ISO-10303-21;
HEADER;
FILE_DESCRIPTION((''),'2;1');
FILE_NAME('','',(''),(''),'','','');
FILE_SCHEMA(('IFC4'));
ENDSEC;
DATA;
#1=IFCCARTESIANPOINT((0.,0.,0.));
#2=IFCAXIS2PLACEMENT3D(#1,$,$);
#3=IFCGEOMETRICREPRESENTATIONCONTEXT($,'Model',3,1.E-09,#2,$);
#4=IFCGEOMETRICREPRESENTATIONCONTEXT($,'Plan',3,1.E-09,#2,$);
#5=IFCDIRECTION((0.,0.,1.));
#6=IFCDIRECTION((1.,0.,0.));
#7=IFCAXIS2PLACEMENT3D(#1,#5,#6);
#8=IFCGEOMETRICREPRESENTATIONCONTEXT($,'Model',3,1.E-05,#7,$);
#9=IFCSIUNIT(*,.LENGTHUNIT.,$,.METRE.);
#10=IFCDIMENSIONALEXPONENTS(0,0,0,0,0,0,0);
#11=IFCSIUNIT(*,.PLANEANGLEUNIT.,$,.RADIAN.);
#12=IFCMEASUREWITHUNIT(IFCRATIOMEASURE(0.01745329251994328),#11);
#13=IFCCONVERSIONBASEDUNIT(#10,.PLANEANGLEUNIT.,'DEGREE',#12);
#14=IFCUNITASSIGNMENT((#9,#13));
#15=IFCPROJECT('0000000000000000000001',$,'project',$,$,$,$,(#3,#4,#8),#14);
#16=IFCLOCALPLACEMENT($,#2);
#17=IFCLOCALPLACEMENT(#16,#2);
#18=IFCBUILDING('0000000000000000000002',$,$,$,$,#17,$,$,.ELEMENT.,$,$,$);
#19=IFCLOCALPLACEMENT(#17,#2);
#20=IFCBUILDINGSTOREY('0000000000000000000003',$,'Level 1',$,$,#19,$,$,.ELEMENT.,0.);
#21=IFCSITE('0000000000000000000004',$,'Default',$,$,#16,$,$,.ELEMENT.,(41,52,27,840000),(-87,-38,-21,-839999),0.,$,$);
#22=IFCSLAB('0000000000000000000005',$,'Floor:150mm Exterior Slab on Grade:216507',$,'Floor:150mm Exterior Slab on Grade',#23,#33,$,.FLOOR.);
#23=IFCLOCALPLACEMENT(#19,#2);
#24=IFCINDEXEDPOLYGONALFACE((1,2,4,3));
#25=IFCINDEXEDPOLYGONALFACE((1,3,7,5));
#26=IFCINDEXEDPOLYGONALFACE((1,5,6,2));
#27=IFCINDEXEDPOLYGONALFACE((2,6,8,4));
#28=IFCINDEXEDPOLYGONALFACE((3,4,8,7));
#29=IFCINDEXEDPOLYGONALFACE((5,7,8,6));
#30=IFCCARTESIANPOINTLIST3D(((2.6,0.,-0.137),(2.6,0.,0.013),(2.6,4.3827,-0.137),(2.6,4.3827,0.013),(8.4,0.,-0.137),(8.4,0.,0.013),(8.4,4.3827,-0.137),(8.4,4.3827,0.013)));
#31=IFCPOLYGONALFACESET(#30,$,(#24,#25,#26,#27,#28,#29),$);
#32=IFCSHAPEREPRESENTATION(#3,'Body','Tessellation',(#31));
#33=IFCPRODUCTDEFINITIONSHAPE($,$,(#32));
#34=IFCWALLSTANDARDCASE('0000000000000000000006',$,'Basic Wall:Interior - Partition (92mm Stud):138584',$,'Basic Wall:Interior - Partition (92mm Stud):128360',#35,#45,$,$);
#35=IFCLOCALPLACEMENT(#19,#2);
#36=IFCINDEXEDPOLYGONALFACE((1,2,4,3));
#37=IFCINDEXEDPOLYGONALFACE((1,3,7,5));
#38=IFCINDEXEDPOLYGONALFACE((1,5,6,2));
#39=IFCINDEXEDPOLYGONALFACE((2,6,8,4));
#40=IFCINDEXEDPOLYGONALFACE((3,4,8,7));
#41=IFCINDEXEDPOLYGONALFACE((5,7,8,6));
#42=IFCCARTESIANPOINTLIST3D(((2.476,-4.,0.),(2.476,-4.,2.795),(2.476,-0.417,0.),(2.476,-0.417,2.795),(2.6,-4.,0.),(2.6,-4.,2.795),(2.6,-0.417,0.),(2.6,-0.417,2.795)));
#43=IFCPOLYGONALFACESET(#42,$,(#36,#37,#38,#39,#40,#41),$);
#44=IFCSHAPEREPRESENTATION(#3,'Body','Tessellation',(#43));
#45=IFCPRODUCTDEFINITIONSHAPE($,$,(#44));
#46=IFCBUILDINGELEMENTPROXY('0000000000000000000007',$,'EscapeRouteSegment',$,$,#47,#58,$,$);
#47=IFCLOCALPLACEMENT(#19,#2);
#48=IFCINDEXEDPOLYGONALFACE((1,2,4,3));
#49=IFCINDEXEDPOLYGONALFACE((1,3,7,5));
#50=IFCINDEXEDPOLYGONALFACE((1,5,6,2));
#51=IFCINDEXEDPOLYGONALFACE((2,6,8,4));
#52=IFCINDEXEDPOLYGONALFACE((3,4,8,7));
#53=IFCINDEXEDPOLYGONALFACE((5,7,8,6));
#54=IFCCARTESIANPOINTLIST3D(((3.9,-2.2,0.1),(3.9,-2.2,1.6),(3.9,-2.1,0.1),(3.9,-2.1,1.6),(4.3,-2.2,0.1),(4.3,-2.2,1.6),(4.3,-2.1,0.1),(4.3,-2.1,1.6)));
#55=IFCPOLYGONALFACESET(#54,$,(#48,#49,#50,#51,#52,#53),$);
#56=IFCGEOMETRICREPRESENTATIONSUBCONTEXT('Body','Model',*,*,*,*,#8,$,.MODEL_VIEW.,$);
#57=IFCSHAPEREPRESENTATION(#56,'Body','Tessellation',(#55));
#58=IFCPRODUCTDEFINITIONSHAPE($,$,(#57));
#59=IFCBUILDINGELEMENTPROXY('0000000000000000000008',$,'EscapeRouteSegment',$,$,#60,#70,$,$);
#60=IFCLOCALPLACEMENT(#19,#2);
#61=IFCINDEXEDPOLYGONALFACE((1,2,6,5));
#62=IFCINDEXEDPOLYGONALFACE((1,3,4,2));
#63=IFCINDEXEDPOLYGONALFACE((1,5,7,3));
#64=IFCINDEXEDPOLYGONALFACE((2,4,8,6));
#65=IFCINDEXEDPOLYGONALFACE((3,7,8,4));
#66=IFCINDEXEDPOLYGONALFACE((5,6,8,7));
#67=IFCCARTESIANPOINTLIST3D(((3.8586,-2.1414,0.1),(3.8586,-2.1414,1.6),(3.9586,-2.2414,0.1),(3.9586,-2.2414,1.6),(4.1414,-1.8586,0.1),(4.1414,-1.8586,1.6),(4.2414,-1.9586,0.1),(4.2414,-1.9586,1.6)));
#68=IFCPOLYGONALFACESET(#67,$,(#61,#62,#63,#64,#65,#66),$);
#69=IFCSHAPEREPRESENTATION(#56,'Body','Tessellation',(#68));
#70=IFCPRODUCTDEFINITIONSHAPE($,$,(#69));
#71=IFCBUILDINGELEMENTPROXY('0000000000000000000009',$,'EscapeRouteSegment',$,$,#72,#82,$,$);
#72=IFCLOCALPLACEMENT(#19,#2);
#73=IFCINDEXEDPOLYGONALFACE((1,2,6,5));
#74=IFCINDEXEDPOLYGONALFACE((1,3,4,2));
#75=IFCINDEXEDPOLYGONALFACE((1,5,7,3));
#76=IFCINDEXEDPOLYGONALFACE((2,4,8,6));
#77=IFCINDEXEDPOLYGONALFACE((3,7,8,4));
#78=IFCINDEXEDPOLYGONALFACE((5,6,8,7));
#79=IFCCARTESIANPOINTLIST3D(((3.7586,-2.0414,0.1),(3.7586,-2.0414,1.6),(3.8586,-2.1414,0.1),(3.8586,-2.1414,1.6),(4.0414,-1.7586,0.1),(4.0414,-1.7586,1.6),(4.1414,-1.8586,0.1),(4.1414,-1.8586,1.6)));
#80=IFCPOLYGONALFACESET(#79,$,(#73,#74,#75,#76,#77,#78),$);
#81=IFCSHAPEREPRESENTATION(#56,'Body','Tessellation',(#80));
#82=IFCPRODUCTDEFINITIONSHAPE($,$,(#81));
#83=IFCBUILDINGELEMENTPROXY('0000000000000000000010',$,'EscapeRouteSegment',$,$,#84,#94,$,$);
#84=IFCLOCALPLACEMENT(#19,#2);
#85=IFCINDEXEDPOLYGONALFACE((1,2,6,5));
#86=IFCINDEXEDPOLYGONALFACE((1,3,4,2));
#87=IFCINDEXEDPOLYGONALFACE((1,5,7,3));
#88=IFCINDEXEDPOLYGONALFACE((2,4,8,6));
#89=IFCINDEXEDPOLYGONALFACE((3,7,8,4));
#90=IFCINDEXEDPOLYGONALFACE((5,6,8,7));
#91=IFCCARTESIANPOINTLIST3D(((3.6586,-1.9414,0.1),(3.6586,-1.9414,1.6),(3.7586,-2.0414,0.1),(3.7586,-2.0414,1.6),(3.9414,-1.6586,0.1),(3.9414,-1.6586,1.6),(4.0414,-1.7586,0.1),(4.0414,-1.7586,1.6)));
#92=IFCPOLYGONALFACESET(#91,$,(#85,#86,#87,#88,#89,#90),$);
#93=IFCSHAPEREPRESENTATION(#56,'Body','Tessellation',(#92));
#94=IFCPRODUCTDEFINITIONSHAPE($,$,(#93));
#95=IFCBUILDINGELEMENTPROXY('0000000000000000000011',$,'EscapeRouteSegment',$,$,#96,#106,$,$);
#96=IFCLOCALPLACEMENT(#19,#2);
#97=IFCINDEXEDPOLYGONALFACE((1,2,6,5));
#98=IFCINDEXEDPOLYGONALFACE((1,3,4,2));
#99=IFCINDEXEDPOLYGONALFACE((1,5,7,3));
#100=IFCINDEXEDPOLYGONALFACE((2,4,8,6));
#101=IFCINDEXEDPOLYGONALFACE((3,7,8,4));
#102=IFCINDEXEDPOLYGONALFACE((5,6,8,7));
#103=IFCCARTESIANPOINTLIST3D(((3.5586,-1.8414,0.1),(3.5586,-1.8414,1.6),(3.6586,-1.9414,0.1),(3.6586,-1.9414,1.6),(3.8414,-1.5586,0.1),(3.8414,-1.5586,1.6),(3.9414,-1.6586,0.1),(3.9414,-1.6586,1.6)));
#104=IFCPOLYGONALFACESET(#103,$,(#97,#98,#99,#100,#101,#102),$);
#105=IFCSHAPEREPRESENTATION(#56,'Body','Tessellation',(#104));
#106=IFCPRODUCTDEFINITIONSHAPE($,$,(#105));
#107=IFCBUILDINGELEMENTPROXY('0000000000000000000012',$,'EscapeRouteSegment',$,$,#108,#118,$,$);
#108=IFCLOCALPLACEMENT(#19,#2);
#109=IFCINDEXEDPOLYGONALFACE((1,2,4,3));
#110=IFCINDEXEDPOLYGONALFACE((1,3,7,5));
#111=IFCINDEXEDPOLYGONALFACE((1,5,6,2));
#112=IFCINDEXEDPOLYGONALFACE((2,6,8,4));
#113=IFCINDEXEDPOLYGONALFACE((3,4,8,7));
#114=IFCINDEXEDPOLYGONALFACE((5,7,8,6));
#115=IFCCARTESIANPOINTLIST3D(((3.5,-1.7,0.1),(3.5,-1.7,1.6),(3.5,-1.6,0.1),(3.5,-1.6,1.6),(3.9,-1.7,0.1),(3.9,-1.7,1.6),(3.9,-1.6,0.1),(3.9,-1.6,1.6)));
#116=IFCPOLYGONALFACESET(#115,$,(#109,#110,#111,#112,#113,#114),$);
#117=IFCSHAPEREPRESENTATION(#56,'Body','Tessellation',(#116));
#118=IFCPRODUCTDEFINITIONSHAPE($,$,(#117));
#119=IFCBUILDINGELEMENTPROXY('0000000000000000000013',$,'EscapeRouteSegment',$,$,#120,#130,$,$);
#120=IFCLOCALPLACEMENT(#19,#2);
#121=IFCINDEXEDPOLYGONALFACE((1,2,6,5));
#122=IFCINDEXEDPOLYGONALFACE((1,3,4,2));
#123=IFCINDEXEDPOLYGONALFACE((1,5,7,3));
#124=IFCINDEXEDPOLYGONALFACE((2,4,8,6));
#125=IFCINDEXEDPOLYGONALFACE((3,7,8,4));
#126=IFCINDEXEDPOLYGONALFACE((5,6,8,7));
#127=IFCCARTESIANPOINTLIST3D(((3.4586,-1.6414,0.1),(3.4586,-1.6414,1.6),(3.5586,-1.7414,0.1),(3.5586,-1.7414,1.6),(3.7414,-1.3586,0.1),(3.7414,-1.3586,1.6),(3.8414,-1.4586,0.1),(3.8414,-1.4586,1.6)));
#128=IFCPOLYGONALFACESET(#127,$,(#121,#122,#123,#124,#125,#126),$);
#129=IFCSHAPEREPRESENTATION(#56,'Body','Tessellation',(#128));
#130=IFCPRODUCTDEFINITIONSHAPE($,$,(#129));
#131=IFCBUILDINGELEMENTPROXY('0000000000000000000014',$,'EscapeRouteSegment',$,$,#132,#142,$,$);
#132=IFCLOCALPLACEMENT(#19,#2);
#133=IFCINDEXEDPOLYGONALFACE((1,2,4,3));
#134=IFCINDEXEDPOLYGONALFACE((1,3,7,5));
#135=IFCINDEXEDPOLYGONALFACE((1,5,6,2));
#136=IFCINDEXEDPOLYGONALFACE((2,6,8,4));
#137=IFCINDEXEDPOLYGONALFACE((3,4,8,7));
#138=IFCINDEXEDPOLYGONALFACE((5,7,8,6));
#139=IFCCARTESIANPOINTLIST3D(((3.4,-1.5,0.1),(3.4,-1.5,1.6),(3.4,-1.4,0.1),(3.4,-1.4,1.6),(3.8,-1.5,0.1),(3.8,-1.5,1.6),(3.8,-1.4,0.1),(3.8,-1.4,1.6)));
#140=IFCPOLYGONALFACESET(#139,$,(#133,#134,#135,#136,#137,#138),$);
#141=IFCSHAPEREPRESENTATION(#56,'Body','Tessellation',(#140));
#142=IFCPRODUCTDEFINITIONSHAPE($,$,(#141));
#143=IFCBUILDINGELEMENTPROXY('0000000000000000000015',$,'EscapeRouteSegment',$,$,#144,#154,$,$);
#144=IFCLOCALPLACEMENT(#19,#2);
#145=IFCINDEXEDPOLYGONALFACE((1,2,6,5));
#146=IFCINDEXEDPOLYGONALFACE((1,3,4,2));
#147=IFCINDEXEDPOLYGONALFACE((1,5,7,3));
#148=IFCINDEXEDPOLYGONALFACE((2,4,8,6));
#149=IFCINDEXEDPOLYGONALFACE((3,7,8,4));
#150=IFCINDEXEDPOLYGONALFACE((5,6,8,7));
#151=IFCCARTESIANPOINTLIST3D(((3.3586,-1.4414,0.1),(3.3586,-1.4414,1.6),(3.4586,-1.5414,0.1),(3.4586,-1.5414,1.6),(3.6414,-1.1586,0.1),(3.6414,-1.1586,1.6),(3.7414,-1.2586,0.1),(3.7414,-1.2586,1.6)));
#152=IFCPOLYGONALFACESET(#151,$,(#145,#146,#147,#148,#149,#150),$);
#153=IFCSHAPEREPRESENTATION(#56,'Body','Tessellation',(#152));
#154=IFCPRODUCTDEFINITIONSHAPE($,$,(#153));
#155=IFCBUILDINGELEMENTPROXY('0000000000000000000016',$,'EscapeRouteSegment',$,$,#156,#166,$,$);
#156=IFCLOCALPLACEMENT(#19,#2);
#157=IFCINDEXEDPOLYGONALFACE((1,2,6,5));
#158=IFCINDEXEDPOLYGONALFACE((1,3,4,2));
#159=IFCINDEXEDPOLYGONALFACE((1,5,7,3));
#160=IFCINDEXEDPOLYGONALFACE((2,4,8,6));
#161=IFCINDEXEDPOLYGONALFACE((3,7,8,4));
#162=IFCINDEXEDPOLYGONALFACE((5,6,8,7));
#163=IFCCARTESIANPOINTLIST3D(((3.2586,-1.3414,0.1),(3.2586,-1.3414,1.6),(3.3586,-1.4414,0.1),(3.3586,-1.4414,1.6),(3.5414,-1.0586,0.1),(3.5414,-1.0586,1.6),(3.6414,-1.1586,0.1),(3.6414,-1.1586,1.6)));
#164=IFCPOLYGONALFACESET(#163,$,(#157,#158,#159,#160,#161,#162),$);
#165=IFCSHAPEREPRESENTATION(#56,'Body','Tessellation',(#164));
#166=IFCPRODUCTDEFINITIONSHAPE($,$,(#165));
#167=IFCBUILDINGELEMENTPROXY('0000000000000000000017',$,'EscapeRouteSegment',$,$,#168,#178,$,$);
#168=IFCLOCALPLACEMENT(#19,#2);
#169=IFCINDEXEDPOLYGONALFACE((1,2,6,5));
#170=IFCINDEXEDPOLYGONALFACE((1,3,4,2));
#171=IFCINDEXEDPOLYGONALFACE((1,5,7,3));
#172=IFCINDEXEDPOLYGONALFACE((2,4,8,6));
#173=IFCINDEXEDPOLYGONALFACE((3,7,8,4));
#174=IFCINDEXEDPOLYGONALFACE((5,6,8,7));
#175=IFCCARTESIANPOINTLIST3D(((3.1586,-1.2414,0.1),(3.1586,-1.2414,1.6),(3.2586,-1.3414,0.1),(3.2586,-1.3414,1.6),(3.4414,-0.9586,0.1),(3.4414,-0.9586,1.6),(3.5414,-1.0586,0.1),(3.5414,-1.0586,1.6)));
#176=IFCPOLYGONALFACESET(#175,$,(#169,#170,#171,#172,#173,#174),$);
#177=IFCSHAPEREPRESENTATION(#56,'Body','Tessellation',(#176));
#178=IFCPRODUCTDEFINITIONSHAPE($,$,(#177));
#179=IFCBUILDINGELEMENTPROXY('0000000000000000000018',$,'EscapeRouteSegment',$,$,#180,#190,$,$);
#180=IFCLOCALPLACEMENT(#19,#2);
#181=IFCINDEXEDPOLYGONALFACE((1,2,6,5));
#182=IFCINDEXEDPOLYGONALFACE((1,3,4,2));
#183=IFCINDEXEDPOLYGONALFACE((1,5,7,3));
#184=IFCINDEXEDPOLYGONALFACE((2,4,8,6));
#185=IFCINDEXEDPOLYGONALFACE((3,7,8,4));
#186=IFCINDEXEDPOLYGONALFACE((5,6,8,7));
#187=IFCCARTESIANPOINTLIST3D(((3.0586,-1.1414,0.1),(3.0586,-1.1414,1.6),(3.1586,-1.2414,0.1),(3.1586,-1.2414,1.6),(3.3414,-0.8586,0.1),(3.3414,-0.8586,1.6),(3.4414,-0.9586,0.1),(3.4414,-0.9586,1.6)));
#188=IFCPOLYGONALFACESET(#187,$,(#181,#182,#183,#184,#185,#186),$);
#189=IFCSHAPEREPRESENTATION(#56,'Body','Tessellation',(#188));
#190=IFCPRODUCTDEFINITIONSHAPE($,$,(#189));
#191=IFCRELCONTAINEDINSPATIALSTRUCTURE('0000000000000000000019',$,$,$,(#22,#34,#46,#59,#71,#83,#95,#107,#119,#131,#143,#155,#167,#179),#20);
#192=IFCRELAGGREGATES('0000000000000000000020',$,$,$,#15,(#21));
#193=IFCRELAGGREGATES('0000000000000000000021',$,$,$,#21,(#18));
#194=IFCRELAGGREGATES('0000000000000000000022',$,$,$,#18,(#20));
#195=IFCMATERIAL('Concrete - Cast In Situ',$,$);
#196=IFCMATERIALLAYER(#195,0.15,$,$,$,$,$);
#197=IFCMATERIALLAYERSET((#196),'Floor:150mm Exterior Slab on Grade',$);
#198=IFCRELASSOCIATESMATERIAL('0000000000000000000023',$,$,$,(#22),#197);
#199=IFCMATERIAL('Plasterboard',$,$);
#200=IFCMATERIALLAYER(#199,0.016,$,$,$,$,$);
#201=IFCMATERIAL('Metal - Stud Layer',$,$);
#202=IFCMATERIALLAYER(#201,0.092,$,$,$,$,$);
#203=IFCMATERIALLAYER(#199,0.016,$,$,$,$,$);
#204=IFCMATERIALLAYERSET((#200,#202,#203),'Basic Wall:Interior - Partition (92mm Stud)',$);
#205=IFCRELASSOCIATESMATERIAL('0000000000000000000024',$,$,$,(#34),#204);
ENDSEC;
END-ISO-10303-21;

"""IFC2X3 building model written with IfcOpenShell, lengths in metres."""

from ifc_helpers import new_model, entity, si_unit, converted_unit, frame, frame_2d, origin, origin_with_axes, place, context, subcontext, project, spatial, polyline, rectangle, outline, extrude, material, layer, layer_set, layer_usage, element, save


model = new_model("IFC2X3")

# Units and contexts
model_context_1 = context("Model", 3, precision=1e-09, world=origin())
plan_context = context("Plan", 3, precision=1e-09, world=origin())
model_context_2 = context("Model", 3, precision=1e-05, world=origin_with_axes())
body_context = subcontext(model_context_2, "Body", "Model", "MODEL_VIEW")
ifc_project = project(units=[si_unit("LENGTHUNIT", "METRE"), converted_unit("PLANEANGLEUNIT", "DEGREE", entity("IfcRatioMeasure", 0.01745329251994328), si_unit("PLANEANGLEUNIT", "RADIAN"), dimensions=[0, 0, 0, 0, 0, 0, 0])], contexts=[model_context_1, plan_context, model_context_2])

# Site, building, storey
site_placement = place(None, origin())
site = spatial("IfcSite", under=ifc_project, at=site_placement, Name="Default", CompositionType="ELEMENT", RefLatitude=(41, 52, 27, 840000), RefLongitude=(-87, -38, -21, -839999), RefElevation=0.0)
building_placement = place(site_placement, origin())
building = spatial("IfcBuilding", under=site, at=building_placement, CompositionType="ELEMENT")
storey_placement = place(building_placement, origin())
storey = spatial("IfcBuildingStorey", under=building, at=storey_placement, Name="Level 1", CompositionType="ELEMENT", Elevation=0.0)

# Slab
ifc_material_1 = material(Name="Concrete - Cast In Situ")
ifc_layer_1 = layer(ifc_material_1, 0.15)
ifc_layer_set_1 = layer_set([ifc_layer_1], Name="Floor:150mm Exterior Slab on Grade")
ifc_layer_usage_1 = layer_usage(ifc_layer_set_1, "AXIS3", "POSITIVE", 0.0)
slab_placement = place(storey_placement, frame((2.6, 0.0, -0.137)))
element("IfcSlab", 1, at=slab_placement, inside=storey, material=ifc_layer_usage_1, Name="Floor:150mm Exterior Slab on Grade:216507", ObjectType="Floor:150mm Exterior Slab on Grade", PredefinedType="FLOOR", context=model_context_1, shape_type="SweptSolid", body=[
    extrude(rectangle(XDim=5.8, YDim=4.3827, at=frame_2d((0.0, 0.0), x_axis=(-1.0, 0.0))), frame((2.9, 2.1914, 0.15), z_axis=(0.0, 0.0, -1.0), x_axis=(-1.0, 0.0, 0.0)), (0.0, 0.0, 1.0), 0.15),
])

# Wall
ifc_material_2 = material(Name="Plasterboard")
ifc_layer_2 = layer(ifc_material_2, 0.016)
ifc_material_3 = material(Name="Metal - Stud Layer")
ifc_layer_3 = layer(ifc_material_3, 0.092)
ifc_layer_4 = layer(ifc_material_2, 0.016)
ifc_layer_set_2 = layer_set([ifc_layer_2, ifc_layer_3, ifc_layer_4], Name="Basic Wall:Interior - Partition (92mm Stud)")
ifc_layer_usage_2 = layer_usage(ifc_layer_set_2, "AXIS2", "NEGATIVE", 0.062)
wall_placement = place(storey_placement, frame((2.538, -0.417, 0.0), z_axis=(0.0, 0.0, 1.0), x_axis=(0.0, -1.0, 0.0)))
element("IfcWallStandardCase", 2, at=wall_placement, inside=storey, material=ifc_layer_usage_2, Name="Basic Wall:Interior - Partition (92mm Stud):138584", ObjectType="Basic Wall:Interior - Partition (92mm Stud):128360", context=model_context_1, shape_type="SweptSolid", body=[
    extrude(rectangle(XDim=3.583, YDim=0.124, at=frame_2d((1.7915, 0.0), x_axis=(-1.0, 0.0))), origin(), (0.0, 0.0, 1.0), 2.795),
])

# Building element proxies
proxy_1_placement = place(storey_placement, frame((4.1, -2.2, 0.1), z_axis=(0.0, 0.0, 1.0), x_axis=(0.0, 1.0, 0.0)))
element("IfcBuildingElementProxy", 3, at=proxy_1_placement, inside=storey, Name="EscapeRouteSegment", context=body_context, shape_type="SweptSolid", body=[
    extrude(outline(polyline([(0.0, -0.2), (0.0, 0.2), (0.1, 0.2), (0.1, -0.2), (0.0, -0.2)])), origin_with_axes(), (0.0, 0.0, 1.0), 1.5),
])
proxy_2_placement = place(storey_placement, frame((4.1, -2.1, 0.1), z_axis=(0.0, 0.0, 1.0), x_axis=(-0.707107, 0.707107, 0.0)))
element("IfcBuildingElementProxy", 4, at=proxy_2_placement, inside=storey, Name="EscapeRouteSegment", context=body_context, shape_type="SweptSolid", body=[
    extrude(outline(polyline([(0.0, -0.2), (0.0, 0.2), (0.1414, 0.2), (0.1414, -0.2), (0.0, -0.2)])), origin_with_axes(), (0.0, 0.0, 1.0), 1.5),
])
proxy_3_placement = place(storey_placement, frame((4.0, -2.0, 0.1), z_axis=(0.0, 0.0, 1.0), x_axis=(-0.707106, 0.707107, 0.0)))
element("IfcBuildingElementProxy", 5, at=proxy_3_placement, inside=storey, Name="EscapeRouteSegment", context=body_context, shape_type="SweptSolid", body=[
    extrude(outline(polyline([(0.0, -0.2), (0.0, 0.2), (0.1414, 0.2), (0.1414, -0.2), (0.0, -0.2)])), origin_with_axes(), (0.0, 0.0, 1.0), 1.5),
])
proxy_4_placement = place(storey_placement, frame((3.9, -1.9, 0.1), z_axis=(0.0, 0.0, 1.0), x_axis=(-0.707107, 0.707106, 0.0)))
element("IfcBuildingElementProxy", 6, at=proxy_4_placement, inside=storey, Name="EscapeRouteSegment", context=body_context, shape_type="SweptSolid", body=[
    extrude(outline(polyline([(0.0, -0.2), (0.0, 0.2), (0.1414, 0.2), (0.1414, -0.2), (0.0, -0.2)])), origin_with_axes(), (0.0, 0.0, 1.0), 1.5),
])
proxy_5_placement = place(storey_placement, frame((3.8, -1.8, 0.1), z_axis=(0.0, 0.0, 1.0), x_axis=(-0.707107, 0.707107, 0.0)))
element("IfcBuildingElementProxy", 7, at=proxy_5_placement, inside=storey, Name="EscapeRouteSegment", context=body_context, shape_type="SweptSolid", body=[
    extrude(outline(polyline([(0.0, -0.2), (0.0, 0.2), (0.1414, 0.2), (0.1414, -0.2), (0.0, -0.2)])), origin_with_axes(), (0.0, 0.0, 1.0), 1.5),
])
proxy_6_placement = place(storey_placement, frame((3.7, -1.7, 0.1), z_axis=(0.0, 0.0, 1.0), x_axis=(0.0, 1.0, 0.0)))
element("IfcBuildingElementProxy", 8, at=proxy_6_placement, inside=storey, Name="EscapeRouteSegment", context=body_context, shape_type="SweptSolid", body=[
    extrude(outline(polyline([(0.0, -0.2), (0.0, 0.2), (0.1, 0.2), (0.1, -0.2), (0.0, -0.2)])), origin_with_axes(), (0.0, 0.0, 1.0), 1.5),
])
proxy_7_placement = place(storey_placement, frame((3.7, -1.6, 0.1), z_axis=(0.0, 0.0, 1.0), x_axis=(-0.707107, 0.707106, 0.0)))
element("IfcBuildingElementProxy", 9, at=proxy_7_placement, inside=storey, Name="EscapeRouteSegment", context=body_context, shape_type="SweptSolid", body=[
    extrude(outline(polyline([(0.0, -0.2), (0.0, 0.2), (0.1414, 0.2), (0.1414, -0.2), (0.0, -0.2)])), origin_with_axes(), (0.0, 0.0, 1.0), 1.5),
])
proxy_8_placement = place(storey_placement, frame((3.6, -1.5, 0.1), z_axis=(0.0, 0.0, 1.0), x_axis=(0.0, 1.0, 0.0)))
element("IfcBuildingElementProxy", 10, at=proxy_8_placement, inside=storey, Name="EscapeRouteSegment", context=body_context, shape_type="SweptSolid", body=[
    extrude(outline(polyline([(0.0, -0.2), (0.0, 0.2), (0.1, 0.2), (0.1, -0.2), (0.0, -0.2)])), origin_with_axes(), (0.0, 0.0, 1.0), 1.5),
])
proxy_9_placement = place(storey_placement, frame((3.6, -1.4, 0.1), z_axis=(0.0, 0.0, 1.0), x_axis=(-0.707106, 0.707107, 0.0)))
element("IfcBuildingElementProxy", 11, at=proxy_9_placement, inside=storey, Name="EscapeRouteSegment", context=body_context, shape_type="SweptSolid", body=[
    extrude(outline(polyline([(0.0, -0.2), (0.0, 0.2), (0.1414, 0.2), (0.1414, -0.2), (0.0, -0.2)])), origin_with_axes(), (0.0, 0.0, 1.0), 1.5),
])
proxy_10_placement = place(storey_placement, frame((3.5, -1.3, 0.1), z_axis=(0.0, 0.0, 1.0), x_axis=(-0.707107, 0.707107, 0.0)))
element("IfcBuildingElementProxy", 12, at=proxy_10_placement, inside=storey, Name="EscapeRouteSegment", context=body_context, shape_type="SweptSolid", body=[
    extrude(outline(polyline([(0.0, -0.2), (0.0, 0.2), (0.1414, 0.2), (0.1414, -0.2), (0.0, -0.2)])), origin_with_axes(), (0.0, 0.0, 1.0), 1.5),
])
proxy_11_placement = place(storey_placement, frame((3.4, -1.2, 0.1), z_axis=(0.0, 0.0, 1.0), x_axis=(-0.707107, 0.707106, 0.0)))
element("IfcBuildingElementProxy", 13, at=proxy_11_placement, inside=storey, Name="EscapeRouteSegment", context=body_context, shape_type="SweptSolid", body=[
    extrude(outline(polyline([(0.0, -0.2), (0.0, 0.2), (0.1414, 0.2), (0.1414, -0.2), (0.0, -0.2)])), origin_with_axes(), (0.0, 0.0, 1.0), 1.5),
])
proxy_12_placement = place(storey_placement, frame((3.3, -1.1, 0.1), z_axis=(0.0, 0.0, 1.0), x_axis=(-0.707106, 0.707107, 0.0)))
element("IfcBuildingElementProxy", 14, at=proxy_12_placement, inside=storey, Name="EscapeRouteSegment", context=body_context, shape_type="SweptSolid", body=[
    extrude(outline(polyline([(0.0, -0.2), (0.0, 0.2), (0.1414, 0.2), (0.1414, -0.2), (0.0, -0.2)])), origin_with_axes(), (0.0, 0.0, 1.0), 1.5),
])

save(model, "model.ifc")
